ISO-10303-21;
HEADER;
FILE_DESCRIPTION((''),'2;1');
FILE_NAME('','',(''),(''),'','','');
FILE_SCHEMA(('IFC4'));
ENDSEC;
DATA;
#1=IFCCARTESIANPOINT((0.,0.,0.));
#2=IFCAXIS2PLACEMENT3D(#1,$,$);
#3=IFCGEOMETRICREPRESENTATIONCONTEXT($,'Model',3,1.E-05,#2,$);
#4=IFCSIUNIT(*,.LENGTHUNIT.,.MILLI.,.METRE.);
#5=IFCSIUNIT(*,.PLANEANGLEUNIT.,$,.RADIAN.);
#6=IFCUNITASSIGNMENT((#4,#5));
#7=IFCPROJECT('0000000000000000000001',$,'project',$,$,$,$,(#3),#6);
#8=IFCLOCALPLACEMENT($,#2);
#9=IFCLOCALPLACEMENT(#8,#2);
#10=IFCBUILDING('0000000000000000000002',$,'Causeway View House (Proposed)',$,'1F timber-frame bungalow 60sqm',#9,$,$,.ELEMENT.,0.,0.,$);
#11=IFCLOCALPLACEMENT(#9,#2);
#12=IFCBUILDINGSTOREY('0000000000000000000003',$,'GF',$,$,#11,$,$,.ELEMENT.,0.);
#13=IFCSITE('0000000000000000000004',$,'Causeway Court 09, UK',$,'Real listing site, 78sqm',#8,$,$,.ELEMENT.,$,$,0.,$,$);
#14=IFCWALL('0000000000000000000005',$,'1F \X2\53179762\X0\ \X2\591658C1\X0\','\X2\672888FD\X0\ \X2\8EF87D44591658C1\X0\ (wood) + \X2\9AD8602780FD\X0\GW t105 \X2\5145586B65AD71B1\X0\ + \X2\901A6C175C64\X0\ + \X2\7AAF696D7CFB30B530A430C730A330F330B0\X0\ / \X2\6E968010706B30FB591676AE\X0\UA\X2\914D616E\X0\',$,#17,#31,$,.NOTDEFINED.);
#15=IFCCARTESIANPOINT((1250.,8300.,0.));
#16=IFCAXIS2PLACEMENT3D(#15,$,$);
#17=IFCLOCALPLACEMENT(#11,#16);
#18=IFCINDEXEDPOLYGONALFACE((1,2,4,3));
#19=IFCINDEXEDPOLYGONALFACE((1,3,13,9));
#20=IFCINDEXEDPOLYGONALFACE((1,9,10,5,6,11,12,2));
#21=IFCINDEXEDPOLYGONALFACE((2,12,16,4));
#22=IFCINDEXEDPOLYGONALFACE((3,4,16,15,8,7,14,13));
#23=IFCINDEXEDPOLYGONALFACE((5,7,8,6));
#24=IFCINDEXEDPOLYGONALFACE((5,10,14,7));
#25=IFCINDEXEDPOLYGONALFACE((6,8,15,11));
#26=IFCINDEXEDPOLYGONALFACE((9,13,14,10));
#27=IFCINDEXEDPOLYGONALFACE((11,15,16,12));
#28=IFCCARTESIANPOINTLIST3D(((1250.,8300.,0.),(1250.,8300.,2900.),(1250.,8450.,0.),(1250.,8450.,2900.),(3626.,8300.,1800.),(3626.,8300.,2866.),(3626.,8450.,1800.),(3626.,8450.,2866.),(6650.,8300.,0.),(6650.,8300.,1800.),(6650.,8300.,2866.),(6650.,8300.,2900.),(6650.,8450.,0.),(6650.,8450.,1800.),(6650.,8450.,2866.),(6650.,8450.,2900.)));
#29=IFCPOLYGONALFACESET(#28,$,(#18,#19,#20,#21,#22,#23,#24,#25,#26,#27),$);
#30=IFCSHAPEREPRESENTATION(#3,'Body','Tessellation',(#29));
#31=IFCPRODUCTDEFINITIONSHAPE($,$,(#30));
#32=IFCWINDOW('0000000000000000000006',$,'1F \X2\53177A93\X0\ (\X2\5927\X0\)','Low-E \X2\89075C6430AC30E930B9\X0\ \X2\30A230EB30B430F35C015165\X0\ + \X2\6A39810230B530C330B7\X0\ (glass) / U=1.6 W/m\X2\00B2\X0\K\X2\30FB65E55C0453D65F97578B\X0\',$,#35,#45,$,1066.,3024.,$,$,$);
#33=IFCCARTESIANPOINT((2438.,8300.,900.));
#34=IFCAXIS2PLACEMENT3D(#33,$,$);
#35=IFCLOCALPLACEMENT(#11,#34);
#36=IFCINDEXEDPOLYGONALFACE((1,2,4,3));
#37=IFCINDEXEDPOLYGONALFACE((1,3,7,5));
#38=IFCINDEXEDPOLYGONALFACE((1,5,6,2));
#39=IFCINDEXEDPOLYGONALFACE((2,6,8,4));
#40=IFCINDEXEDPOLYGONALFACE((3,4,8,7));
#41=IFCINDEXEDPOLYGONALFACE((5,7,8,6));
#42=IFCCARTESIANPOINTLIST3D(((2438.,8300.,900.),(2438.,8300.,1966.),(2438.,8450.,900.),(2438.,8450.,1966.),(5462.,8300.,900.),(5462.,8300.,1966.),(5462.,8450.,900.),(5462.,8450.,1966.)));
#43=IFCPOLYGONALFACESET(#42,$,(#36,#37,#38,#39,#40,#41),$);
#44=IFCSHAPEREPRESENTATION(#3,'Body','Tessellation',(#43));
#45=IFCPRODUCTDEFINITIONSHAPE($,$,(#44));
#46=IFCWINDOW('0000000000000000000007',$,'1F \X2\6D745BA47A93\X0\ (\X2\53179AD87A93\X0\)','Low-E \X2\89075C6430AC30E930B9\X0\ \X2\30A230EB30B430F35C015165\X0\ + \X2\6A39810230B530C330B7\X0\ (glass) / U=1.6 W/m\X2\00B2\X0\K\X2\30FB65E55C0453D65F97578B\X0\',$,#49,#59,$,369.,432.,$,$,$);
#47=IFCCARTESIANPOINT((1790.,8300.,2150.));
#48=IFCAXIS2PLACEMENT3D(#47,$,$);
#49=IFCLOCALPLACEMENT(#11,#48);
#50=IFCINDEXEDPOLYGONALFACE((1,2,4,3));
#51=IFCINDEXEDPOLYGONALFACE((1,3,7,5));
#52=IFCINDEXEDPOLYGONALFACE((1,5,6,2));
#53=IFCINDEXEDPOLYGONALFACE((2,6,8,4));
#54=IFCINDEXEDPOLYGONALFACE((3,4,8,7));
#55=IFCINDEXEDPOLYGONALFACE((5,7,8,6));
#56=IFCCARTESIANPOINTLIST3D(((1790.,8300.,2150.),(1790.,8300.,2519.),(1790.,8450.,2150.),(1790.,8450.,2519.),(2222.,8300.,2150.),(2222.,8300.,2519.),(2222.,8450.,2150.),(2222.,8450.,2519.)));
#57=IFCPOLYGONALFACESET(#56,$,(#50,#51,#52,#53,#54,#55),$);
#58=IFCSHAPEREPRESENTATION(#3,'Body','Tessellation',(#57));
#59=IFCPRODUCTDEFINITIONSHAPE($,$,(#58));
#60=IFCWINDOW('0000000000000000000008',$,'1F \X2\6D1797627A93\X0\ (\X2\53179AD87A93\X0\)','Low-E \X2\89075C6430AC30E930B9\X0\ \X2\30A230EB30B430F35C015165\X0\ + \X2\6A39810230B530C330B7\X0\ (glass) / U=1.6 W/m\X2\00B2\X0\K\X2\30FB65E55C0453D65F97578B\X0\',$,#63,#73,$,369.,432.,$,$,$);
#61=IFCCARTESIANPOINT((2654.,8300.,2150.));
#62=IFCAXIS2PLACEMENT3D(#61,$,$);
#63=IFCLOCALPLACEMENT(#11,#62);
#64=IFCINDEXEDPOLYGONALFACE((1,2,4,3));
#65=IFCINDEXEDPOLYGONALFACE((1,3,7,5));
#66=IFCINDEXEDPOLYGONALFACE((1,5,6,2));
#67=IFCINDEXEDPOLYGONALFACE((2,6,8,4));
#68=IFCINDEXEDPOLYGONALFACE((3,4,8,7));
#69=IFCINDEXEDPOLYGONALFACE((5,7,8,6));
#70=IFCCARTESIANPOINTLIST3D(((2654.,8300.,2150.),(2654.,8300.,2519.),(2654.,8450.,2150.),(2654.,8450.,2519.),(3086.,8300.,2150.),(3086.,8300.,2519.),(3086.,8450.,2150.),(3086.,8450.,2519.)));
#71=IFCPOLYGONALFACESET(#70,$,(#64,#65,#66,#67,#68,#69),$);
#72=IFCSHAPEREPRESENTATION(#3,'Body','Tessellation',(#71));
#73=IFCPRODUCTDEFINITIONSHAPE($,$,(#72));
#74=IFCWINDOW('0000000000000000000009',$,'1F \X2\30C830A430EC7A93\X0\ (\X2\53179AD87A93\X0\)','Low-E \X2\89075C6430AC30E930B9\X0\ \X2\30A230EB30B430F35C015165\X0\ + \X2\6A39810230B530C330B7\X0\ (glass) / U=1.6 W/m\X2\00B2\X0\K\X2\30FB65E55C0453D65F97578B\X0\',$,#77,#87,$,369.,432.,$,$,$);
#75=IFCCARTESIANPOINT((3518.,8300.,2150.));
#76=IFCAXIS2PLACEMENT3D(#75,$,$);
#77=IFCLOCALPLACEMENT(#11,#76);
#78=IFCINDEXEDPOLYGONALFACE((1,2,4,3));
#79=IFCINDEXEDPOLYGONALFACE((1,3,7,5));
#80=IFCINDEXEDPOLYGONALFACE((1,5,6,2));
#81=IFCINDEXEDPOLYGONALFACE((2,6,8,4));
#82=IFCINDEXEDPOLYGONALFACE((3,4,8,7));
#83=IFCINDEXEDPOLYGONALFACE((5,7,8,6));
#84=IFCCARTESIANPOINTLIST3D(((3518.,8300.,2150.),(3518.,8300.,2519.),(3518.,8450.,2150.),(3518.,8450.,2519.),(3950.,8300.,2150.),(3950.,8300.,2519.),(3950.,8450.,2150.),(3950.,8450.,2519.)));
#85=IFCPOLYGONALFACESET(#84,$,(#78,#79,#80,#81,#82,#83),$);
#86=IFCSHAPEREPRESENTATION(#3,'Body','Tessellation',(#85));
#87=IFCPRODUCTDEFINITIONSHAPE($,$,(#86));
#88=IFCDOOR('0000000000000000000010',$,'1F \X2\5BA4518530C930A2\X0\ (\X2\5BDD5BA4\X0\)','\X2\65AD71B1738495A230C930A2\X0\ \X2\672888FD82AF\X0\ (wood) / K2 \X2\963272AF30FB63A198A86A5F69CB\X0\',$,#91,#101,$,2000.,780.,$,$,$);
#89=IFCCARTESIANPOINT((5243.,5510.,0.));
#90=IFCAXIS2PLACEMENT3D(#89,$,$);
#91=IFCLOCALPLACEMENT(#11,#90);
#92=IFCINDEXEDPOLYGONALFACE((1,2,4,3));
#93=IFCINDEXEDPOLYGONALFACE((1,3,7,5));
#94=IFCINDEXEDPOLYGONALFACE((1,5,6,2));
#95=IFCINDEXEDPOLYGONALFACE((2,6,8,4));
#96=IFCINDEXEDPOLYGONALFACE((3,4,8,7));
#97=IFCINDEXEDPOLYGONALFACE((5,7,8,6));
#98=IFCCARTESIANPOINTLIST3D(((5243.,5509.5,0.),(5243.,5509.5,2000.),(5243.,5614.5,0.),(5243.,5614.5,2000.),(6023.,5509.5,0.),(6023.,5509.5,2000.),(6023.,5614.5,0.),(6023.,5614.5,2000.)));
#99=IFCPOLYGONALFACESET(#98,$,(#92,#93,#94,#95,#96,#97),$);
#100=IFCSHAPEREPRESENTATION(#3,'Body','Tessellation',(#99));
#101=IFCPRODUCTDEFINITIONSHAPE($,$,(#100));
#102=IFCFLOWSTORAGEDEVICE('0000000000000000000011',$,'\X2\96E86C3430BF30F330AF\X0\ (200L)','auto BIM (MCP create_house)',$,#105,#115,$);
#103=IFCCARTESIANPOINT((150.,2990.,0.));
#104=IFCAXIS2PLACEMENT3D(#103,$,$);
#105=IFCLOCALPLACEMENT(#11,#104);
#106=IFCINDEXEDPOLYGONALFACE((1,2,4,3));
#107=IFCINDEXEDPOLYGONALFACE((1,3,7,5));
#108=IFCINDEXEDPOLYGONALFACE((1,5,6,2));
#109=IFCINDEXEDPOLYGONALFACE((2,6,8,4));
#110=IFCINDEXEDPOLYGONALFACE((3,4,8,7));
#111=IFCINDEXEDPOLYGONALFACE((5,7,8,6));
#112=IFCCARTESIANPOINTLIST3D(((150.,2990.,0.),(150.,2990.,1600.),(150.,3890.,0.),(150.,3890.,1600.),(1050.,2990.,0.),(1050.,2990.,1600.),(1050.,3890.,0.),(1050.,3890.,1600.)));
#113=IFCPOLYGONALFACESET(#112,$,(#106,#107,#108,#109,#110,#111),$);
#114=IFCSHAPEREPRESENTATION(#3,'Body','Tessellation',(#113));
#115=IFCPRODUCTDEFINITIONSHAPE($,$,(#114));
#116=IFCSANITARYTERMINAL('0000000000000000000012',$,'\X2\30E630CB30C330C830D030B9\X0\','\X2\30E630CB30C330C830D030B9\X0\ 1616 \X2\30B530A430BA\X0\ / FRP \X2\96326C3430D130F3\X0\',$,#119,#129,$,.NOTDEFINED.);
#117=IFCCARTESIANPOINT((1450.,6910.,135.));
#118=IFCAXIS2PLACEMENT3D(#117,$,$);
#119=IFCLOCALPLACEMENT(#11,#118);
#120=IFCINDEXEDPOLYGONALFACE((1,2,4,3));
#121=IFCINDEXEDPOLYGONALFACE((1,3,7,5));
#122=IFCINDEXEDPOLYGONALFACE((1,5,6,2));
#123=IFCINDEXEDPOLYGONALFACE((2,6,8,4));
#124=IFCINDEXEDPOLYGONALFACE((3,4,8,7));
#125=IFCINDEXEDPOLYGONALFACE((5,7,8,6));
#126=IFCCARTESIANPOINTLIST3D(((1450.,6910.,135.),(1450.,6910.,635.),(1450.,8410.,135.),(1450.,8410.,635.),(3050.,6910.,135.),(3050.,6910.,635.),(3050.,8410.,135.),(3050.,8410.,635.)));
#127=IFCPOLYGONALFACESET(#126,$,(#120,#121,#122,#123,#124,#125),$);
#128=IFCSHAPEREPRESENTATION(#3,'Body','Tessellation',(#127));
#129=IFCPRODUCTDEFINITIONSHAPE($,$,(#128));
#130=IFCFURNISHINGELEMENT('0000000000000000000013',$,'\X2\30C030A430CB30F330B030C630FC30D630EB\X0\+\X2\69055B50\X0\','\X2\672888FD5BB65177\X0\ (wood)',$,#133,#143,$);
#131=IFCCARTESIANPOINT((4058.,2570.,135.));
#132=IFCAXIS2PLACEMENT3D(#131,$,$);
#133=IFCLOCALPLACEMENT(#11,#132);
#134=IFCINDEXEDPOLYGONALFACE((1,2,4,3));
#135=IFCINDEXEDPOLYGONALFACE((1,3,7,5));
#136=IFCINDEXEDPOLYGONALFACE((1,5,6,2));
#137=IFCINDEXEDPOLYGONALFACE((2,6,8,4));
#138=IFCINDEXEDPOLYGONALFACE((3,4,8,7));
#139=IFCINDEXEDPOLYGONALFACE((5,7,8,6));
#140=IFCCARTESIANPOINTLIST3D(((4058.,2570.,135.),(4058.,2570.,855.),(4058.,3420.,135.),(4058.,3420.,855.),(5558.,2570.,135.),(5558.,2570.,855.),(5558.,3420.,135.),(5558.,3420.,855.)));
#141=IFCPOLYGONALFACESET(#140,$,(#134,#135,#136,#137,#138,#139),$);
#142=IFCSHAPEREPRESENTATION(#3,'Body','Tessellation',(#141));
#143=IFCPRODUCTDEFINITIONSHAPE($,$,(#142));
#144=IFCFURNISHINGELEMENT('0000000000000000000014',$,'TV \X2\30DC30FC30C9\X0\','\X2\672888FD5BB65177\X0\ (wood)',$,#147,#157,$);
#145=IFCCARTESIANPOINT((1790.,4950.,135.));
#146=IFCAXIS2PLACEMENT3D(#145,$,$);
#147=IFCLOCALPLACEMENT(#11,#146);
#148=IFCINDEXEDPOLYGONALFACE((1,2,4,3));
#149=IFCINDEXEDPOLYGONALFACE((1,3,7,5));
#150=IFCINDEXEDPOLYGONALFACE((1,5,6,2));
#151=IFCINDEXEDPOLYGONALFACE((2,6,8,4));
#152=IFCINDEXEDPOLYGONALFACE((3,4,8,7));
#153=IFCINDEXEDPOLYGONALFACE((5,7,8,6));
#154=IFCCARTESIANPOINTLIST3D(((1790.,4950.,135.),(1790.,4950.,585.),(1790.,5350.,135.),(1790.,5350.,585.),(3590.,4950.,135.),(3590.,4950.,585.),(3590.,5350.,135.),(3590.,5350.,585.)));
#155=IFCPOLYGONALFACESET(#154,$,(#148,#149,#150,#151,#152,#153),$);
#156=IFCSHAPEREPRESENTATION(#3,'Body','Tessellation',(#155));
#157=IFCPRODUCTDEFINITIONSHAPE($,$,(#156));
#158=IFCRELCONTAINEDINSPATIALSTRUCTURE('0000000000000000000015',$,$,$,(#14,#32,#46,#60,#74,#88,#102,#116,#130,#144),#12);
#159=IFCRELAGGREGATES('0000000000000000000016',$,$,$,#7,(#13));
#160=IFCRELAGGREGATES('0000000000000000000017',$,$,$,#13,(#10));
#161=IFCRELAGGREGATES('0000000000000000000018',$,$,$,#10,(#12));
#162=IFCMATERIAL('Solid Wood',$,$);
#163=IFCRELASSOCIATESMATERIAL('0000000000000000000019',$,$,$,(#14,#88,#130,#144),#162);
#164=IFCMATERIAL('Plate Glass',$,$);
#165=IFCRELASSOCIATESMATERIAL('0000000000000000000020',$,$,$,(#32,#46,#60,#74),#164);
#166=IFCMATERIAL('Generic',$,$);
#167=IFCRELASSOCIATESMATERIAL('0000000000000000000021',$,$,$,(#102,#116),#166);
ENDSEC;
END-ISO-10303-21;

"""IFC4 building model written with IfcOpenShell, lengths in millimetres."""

from ifc_helpers import new_model, si_unit, frame, frame_2d, origin, place, context, project, spatial, rectangle, extrude, material, element, fill, save


model = new_model("IFC4")

# Units and contexts
model_context = context("Model", 3, precision=1e-05, world=origin())
ifc_project = project(units=[si_unit("LENGTHUNIT", "METRE", prefix="MILLI"), si_unit("PLANEANGLEUNIT", "RADIAN")], contexts=[model_context])

# Site, building, storey
site_placement = place(None, origin())
site = spatial("IfcSite", under=ifc_project, at=site_placement, Name="Causeway Court 09, UK", ObjectType="Real listing site, 78sqm", CompositionType="ELEMENT", RefElevation=0.0)
building_placement = place(site_placement, origin())
building = spatial("IfcBuilding", under=site, at=building_placement, Name="Causeway View House (Proposed)", ObjectType="1F timber-frame bungalow 60sqm", CompositionType="ELEMENT", ElevationOfRefHeight=0.0, ElevationOfTerrain=0.0)
storey_placement = place(building_placement, origin())
storey = spatial("IfcBuildingStorey", under=building, at=storey_placement, Name="GF", CompositionType="ELEMENT", Elevation=0.0)

# Wall, openings, windows
ifc_material_1 = material(Name="Solid Wood")
wall_1_placement = place(storey_placement, frame((1250.0, 8300.0, 0.0)))
wall_1 = element("IfcWall", 1, at=wall_1_placement, inside=storey, material=ifc_material_1, Name="1F 北面 外壁", Description="木製 軸組外壁 (wood) + 高性能GW t105 充填断熱 + 通気層 + 窯業系サイディング / 準耐火・外皮UA配慮", PredefinedType="NOTDEFINED", context=model_context, shape_type="SweptSolid", body=[
    extrude(rectangle(XDim=5400.0, YDim=150.0, at=frame_2d((2700.0, 75.0))), frame((1250.0, 8300.0, 0.0)), (0.0, 0.0, 1.0), 2900.0),
])
opening_1_placement = place(storey_placement, frame((2438.0, 8300.0, 900.0)))
opening_1 = element("IfcOpeningElement", 2, at=opening_1_placement, cuts=wall_1, PredefinedType="NOTDEFINED", context=model_context, shape_type="SweptSolid", body=[
    extrude(rectangle(XDim=3024.0, YDim=150.0, at=frame_2d((1512.0, 75.0))), frame((2438.0, 8300.0, 900.0)), (0.0, 0.0, 1.0), 1066.0),
])
opening_2_placement = place(storey_placement, frame((1790.0, 8300.0, 2150.0)))
opening_2 = element("IfcOpeningElement", 3, at=opening_2_placement, cuts=wall_1, PredefinedType="NOTDEFINED", context=model_context, shape_type="SweptSolid", body=[
    extrude(rectangle(XDim=432.0, YDim=150.0, at=frame_2d((216.0, 75.0))), frame((1790.0, 8300.0, 2150.0)), (0.0, 0.0, 1.0), 369.0),
])
opening_3_placement = place(storey_placement, frame((2654.0, 8300.0, 2150.0)))
opening_3 = element("IfcOpeningElement", 4, at=opening_3_placement, cuts=wall_1, PredefinedType="NOTDEFINED", context=model_context, shape_type="SweptSolid", body=[
    extrude(rectangle(XDim=432.0, YDim=150.0, at=frame_2d((216.0, 75.0))), frame((2654.0, 8300.0, 2150.0)), (0.0, 0.0, 1.0), 369.0),
])
opening_4_placement = place(storey_placement, frame((3518.0, 8300.0, 2150.0)))
opening_4 = element("IfcOpeningElement", 5, at=opening_4_placement, cuts=wall_1, PredefinedType="NOTDEFINED", context=model_context, shape_type="SweptSolid", body=[
    extrude(rectangle(XDim=432.0, YDim=150.0, at=frame_2d((216.0, 75.0))), frame((3518.0, 8300.0, 2150.0)), (0.0, 0.0, 1.0), 369.0),
])
ifc_material_2 = material(Name="Plate Glass")
window_1_placement = place(storey_placement, frame((2438.0, 8300.0, 900.0)))
window_1 = element("IfcWindow", 6, at=window_1_placement, inside=storey, material=ifc_material_2, Name="1F 北窓 (大)", Description="Low-E 複層ガラス アルゴン封入 + 樹脂サッシ (glass) / U=1.6 W/m²K・日射取得型", OverallHeight=1066.0, OverallWidth=3024.0, context=model_context, shape_type="SweptSolid", body=[
    extrude(rectangle(XDim=3024.0, YDim=150.0, at=frame_2d((1512.0, 75.0))), frame((2438.0, 8300.0, 900.0)), (0.0, 0.0, 1.0), 1066.0),
])
fill(opening_1, window_1)
window_2_placement = place(storey_placement, frame((1790.0, 8300.0, 2150.0)))
window_2 = element("IfcWindow", 7, at=window_2_placement, inside=storey, material=ifc_material_2, Name="1F 浴室窓 (北高窓)", Description="Low-E 複層ガラス アルゴン封入 + 樹脂サッシ (glass) / U=1.6 W/m²K・日射取得型", OverallHeight=369.0, OverallWidth=432.0, context=model_context, shape_type="SweptSolid", body=[
    extrude(rectangle(XDim=432.0, YDim=150.0, at=frame_2d((216.0, 75.0))), frame((1790.0, 8300.0, 2150.0)), (0.0, 0.0, 1.0), 369.0),
])
fill(opening_2, window_2)
window_3_placement = place(storey_placement, frame((2654.0, 8300.0, 2150.0)))
window_3 = element("IfcWindow", 8, at=window_3_placement, inside=storey, material=ifc_material_2, Name="1F 洗面窓 (北高窓)", Description="Low-E 複層ガラス アルゴン封入 + 樹脂サッシ (glass) / U=1.6 W/m²K・日射取得型", OverallHeight=369.0, OverallWidth=432.0, context=model_context, shape_type="SweptSolid", body=[
    extrude(rectangle(XDim=432.0, YDim=150.0, at=frame_2d((216.0, 75.0))), frame((2654.0, 8300.0, 2150.0)), (0.0, 0.0, 1.0), 369.0),
])
fill(opening_3, window_3)
window_4_placement = place(storey_placement, frame((3518.0, 8300.0, 2150.0)))
window_4 = element("IfcWindow", 9, at=window_4_placement, inside=storey, material=ifc_material_2, Name="1F トイレ窓 (北高窓)", Description="Low-E 複層ガラス アルゴン封入 + 樹脂サッシ (glass) / U=1.6 W/m²K・日射取得型", OverallHeight=369.0, OverallWidth=432.0, context=model_context, shape_type="SweptSolid", body=[
    extrude(rectangle(XDim=432.0, YDim=150.0, at=frame_2d((216.0, 75.0))), frame((3518.0, 8300.0, 2150.0)), (0.0, 0.0, 1.0), 369.0),
])
fill(opening_4, window_4)

# Door
door_1_placement = place(storey_placement, frame((5243.0, 5510.0, 0.0)))
element("IfcDoor", 10, at=door_1_placement, inside=storey, material=ifc_material_1, Name="1F 室内ドア (寝室)", Description="断熱玄関ドア 木製芯 (wood) / K2 防犯・採風機構", OverallHeight=2000.0, OverallWidth=780.0, context=model_context, shape_type="SweptSolid", body=[
    extrude(rectangle(XDim=780.0, YDim=105.0, at=frame_2d((390.0, 52.0))), frame((5243.0, 5510.0, 0.0)), (0.0, 0.0, 1.0), 2000.0),
])

# Flow storage device
ifc_material_3 = material(Name="Generic")
flow_storage_device_placement = place(storey_placement, frame((150.0, 2990.0, 0.0)))
element("IfcFlowStorageDevice", 11, at=flow_storage_device_placement, inside=storey, material=ifc_material_3, Name="雨水タンク (200L)", Description="auto BIM (MCP create_house)", context=model_context, shape_type="SweptSolid", body=[
    extrude(rectangle(XDim=900.0, YDim=900.0, at=frame_2d((450.0, 450.0))), frame((150.0, 2990.0, 0.0)), (0.0, 0.0, 1.0), 1600.0),
])

# Sanitary terminal
sanitary_terminal_placement = place(storey_placement, frame((1450.0, 6910.0, 135.0)))
element("IfcSanitaryTerminal", 12, at=sanitary_terminal_placement, inside=storey, material=ifc_material_3, Name="ユニットバス", Description="ユニットバス 1616 サイズ / FRP 防水パン", PredefinedType="NOTDEFINED", context=model_context, shape_type="SweptSolid", body=[
    extrude(rectangle(XDim=1600.0, YDim=1500.0, at=frame_2d((800.0, 750.0))), frame((1450.0, 6910.0, 135.0)), (0.0, 0.0, 1.0), 500.0),
])

# Furnishing elements
furnishing_1_placement = place(storey_placement, frame((4058.0, 2570.0, 135.0)))
element("IfcFurnishingElement", 13, at=furnishing_1_placement, inside=storey, material=ifc_material_1, Name="ダイニングテーブル+椅子", Description="木製家具 (wood)", context=model_context, shape_type="SweptSolid", body=[
    extrude(rectangle(XDim=1500.0, YDim=850.0, at=frame_2d((750.0, 425.0))), frame((4058.0, 2570.0, 135.0)), (0.0, 0.0, 1.0), 720.0),
])
furnishing_2_placement = place(storey_placement, frame((1790.0, 4950.0, 135.0)))
element("IfcFurnishingElement", 14, at=furnishing_2_placement, inside=storey, material=ifc_material_1, Name="TV ボード", Description="木製家具 (wood)", context=model_context, shape_type="SweptSolid", body=[
    extrude(rectangle(XDim=1800.0, YDim=400.0, at=frame_2d((900.0, 200.0))), frame((1790.0, 4950.0, 135.0)), (0.0, 0.0, 1.0), 450.0),
])

save(model, "model.ifc")
